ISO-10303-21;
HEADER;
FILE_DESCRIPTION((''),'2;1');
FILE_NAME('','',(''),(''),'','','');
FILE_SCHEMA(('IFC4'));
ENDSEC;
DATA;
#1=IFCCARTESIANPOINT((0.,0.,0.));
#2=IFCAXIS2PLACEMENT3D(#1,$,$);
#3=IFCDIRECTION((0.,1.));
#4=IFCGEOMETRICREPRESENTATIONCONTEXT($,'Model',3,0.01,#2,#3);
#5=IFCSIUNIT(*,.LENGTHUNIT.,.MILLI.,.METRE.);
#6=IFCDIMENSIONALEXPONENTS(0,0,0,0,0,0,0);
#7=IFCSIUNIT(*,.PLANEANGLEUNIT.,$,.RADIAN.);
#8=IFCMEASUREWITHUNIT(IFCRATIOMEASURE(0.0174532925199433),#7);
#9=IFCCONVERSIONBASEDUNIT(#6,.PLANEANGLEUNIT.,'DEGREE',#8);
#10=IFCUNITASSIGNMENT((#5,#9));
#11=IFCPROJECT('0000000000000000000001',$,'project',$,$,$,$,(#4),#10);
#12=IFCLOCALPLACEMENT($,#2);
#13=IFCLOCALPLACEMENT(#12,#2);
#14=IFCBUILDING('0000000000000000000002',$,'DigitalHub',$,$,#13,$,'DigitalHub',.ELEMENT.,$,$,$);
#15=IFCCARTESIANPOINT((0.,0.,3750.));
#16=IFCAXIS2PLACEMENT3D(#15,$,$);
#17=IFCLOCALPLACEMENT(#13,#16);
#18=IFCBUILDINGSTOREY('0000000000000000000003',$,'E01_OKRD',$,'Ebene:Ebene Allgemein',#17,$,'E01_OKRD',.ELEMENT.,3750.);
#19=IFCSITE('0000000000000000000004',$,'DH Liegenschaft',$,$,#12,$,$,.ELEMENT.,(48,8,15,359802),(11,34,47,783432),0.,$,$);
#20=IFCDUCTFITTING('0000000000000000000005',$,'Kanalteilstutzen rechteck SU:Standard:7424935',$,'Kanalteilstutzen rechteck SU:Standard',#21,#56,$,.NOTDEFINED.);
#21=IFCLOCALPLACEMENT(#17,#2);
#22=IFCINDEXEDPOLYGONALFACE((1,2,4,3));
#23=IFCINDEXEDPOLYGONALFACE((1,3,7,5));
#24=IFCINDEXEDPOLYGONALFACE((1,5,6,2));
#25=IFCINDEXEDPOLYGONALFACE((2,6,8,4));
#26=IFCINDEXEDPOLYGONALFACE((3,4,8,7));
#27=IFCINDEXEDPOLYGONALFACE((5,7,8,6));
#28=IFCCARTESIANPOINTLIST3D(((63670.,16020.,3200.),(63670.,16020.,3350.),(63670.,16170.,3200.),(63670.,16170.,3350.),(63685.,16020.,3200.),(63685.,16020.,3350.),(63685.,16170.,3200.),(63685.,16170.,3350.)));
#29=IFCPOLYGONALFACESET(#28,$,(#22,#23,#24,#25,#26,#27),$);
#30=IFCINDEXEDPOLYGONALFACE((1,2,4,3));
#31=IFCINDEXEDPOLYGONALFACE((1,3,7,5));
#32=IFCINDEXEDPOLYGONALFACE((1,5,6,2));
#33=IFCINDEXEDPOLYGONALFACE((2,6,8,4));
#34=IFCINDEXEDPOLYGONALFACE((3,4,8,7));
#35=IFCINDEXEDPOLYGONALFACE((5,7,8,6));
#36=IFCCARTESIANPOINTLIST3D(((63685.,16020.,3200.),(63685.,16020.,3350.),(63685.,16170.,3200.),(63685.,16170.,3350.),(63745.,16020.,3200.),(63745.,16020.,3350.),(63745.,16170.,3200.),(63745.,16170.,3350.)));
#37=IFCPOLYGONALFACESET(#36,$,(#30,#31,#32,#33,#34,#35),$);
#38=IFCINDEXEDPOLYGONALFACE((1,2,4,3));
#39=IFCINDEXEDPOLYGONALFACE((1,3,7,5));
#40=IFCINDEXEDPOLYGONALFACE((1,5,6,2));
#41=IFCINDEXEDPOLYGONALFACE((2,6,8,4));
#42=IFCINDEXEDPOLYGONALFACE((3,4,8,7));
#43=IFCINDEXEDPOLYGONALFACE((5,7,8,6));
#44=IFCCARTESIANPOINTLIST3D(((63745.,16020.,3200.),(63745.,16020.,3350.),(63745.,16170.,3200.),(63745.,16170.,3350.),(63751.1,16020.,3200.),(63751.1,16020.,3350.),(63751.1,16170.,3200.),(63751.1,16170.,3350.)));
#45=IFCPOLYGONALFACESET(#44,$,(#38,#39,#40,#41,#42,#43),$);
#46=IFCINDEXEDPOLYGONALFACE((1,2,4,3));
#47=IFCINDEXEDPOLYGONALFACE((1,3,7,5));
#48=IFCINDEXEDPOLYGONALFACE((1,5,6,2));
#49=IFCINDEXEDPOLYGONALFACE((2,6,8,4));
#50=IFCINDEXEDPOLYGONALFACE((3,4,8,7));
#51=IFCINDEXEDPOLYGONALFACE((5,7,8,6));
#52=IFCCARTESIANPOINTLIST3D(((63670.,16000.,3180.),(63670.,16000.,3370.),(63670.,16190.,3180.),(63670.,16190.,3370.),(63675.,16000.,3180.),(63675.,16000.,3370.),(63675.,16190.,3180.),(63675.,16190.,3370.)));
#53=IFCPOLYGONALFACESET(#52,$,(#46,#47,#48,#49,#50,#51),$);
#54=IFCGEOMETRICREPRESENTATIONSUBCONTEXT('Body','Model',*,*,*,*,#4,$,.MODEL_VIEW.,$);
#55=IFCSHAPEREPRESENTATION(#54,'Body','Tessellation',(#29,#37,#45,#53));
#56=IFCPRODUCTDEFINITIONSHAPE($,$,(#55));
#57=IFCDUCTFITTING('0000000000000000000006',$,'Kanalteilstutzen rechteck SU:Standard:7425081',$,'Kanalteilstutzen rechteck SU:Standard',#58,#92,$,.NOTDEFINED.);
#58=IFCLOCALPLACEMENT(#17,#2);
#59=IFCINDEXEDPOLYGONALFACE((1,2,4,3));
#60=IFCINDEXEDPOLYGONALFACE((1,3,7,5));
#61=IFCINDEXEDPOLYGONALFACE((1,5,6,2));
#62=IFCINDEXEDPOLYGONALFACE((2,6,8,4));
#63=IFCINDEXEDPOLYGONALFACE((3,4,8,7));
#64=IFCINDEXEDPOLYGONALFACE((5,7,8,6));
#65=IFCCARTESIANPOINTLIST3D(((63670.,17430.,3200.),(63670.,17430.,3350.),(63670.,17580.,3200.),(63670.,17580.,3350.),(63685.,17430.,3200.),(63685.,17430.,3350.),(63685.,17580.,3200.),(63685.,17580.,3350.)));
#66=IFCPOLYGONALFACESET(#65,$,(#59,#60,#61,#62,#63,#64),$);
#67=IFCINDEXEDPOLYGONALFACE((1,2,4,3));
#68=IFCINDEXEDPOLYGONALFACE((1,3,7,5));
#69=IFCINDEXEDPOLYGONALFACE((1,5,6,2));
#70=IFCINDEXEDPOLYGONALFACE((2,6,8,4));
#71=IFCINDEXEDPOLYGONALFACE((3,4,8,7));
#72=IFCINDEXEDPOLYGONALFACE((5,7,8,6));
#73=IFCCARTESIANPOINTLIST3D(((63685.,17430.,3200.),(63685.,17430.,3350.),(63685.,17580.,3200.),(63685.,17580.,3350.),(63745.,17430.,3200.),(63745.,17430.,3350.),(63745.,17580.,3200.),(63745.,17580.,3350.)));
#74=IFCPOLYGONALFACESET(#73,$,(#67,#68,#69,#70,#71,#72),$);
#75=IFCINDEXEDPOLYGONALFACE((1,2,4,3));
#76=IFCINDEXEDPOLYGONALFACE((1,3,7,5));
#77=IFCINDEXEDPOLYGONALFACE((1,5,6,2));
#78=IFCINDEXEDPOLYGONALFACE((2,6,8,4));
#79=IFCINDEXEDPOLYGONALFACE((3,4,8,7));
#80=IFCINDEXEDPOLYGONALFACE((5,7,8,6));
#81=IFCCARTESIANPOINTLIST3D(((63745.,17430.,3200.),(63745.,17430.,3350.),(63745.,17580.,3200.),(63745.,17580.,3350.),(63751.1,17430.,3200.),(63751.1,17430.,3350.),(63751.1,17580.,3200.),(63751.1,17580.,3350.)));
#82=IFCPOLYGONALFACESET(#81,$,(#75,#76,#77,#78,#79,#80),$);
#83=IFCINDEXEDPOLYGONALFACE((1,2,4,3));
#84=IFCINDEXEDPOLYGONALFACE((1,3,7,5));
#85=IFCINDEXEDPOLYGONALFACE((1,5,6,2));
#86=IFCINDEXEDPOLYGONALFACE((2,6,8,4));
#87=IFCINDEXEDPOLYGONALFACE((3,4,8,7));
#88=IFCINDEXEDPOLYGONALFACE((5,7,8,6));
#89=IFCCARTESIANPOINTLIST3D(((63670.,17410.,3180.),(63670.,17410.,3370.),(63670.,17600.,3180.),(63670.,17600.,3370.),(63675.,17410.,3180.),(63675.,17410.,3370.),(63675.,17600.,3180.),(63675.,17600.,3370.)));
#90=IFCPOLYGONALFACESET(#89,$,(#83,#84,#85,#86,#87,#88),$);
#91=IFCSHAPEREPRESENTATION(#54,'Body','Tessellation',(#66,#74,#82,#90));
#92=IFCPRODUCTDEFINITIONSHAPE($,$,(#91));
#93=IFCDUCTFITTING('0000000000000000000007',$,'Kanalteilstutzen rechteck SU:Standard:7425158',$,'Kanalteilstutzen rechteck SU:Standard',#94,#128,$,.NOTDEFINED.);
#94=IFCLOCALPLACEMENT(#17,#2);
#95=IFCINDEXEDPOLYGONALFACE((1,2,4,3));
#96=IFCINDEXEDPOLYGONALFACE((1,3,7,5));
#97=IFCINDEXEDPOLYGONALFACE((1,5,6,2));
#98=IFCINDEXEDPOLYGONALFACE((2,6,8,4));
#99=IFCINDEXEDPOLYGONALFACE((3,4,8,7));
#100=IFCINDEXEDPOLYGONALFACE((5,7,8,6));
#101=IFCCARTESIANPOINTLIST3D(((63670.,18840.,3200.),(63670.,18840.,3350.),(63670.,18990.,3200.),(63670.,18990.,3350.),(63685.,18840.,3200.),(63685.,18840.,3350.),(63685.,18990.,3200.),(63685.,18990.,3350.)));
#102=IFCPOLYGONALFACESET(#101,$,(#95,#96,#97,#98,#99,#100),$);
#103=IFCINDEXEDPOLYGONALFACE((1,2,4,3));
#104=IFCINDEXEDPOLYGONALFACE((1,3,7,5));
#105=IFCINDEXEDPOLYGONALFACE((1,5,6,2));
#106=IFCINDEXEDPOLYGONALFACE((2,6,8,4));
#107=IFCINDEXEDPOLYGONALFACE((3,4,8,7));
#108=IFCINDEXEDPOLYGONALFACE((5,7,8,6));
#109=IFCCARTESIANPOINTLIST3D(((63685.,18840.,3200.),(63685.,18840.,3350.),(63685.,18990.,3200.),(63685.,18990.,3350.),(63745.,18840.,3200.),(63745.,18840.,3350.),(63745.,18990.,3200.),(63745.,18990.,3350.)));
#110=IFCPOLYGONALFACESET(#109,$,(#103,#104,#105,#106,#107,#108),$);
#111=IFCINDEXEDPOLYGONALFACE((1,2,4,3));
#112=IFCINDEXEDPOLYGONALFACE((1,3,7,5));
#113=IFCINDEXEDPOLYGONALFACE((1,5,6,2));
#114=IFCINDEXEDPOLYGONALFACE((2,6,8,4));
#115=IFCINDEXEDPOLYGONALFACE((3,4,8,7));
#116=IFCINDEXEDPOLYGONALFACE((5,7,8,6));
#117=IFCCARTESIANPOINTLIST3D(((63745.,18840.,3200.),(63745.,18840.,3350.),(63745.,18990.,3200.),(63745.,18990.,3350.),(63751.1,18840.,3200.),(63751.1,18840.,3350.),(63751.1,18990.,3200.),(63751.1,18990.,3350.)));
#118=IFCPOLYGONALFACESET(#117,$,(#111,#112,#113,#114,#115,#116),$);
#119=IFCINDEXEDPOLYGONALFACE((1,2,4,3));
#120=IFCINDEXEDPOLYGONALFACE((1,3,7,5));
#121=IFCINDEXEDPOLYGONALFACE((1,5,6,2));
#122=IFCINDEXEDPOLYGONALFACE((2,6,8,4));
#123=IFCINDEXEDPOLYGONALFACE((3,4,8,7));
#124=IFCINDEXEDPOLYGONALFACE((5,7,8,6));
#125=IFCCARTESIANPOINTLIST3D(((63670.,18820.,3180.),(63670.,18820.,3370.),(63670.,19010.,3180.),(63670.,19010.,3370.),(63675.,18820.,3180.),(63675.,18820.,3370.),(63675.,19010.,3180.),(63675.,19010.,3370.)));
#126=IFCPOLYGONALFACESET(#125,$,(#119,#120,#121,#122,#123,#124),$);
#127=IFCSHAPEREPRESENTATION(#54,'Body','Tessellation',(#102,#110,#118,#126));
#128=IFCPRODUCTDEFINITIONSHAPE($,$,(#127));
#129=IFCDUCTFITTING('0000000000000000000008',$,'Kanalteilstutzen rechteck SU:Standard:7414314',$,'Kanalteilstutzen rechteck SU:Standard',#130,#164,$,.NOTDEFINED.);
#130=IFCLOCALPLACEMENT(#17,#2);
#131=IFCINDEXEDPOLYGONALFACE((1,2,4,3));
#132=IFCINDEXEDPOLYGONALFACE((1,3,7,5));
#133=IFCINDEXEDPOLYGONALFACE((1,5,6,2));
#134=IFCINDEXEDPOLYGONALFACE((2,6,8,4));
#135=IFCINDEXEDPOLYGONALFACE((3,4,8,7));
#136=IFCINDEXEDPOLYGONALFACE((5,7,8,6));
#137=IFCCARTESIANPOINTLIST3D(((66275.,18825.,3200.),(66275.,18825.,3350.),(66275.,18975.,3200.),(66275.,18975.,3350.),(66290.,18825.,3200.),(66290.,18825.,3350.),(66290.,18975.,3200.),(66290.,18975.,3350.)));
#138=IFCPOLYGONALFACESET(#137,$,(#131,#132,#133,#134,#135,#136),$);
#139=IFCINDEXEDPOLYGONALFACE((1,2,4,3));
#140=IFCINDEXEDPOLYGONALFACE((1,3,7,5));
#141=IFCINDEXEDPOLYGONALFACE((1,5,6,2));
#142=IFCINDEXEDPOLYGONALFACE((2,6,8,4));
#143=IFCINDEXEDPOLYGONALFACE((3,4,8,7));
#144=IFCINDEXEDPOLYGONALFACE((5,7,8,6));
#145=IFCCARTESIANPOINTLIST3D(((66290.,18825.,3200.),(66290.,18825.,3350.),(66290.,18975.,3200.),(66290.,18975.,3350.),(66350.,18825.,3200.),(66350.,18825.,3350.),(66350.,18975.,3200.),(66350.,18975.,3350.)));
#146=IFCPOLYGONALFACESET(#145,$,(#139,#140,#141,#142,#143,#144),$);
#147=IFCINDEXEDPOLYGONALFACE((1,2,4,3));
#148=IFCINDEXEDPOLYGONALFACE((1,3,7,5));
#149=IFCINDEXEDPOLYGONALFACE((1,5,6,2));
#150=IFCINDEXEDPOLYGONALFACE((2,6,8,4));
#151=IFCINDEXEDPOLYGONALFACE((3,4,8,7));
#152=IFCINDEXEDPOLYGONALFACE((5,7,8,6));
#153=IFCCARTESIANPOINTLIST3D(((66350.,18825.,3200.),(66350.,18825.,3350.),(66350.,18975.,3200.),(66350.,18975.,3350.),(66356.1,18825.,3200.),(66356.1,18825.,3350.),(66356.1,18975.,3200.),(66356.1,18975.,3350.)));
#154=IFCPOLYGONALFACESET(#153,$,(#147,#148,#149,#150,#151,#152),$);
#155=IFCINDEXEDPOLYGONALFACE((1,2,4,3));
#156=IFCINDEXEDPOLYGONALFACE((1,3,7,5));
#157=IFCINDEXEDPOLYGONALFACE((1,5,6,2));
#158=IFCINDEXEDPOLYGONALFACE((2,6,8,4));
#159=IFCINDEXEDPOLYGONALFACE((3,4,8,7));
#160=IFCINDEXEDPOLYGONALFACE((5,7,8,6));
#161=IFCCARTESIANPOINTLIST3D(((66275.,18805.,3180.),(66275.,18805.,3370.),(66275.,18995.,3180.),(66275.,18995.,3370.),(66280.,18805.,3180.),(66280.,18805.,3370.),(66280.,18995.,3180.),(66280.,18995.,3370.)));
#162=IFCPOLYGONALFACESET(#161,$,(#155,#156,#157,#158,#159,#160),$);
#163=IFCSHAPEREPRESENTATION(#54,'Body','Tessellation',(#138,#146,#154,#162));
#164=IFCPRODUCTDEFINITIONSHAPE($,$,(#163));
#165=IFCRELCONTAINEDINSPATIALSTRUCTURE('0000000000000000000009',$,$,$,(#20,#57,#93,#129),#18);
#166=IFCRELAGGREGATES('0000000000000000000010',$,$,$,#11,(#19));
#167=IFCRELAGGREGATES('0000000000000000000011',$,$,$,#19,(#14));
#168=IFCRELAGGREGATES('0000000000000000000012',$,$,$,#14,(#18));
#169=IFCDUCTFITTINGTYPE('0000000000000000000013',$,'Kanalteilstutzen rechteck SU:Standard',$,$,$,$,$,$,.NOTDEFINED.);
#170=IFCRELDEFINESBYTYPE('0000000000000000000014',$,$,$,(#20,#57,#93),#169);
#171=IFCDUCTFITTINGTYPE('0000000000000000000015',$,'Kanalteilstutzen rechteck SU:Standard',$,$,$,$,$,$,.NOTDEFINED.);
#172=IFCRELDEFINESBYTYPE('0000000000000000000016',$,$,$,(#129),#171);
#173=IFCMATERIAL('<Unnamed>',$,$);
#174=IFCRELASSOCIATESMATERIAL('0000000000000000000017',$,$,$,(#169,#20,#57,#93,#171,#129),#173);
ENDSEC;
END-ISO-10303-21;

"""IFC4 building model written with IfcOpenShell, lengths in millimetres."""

from ifc_helpers import new_model, entity, si_unit, converted_unit, direction, frame, origin, place, context, subcontext, project, spatial, indexed_curve, outline, extrude, source, transform, mapped, material, type_object, type_shapes, element, save


model = new_model("IFC4")

# Units and contexts
model_context = context("Model", 3, precision=0.01, world=origin(), true_north=direction((0.0, 1.0)))
body_context = subcontext(model_context, "Body", "Model", "MODEL_VIEW")
ifc_project = project(units=[si_unit("LENGTHUNIT", "METRE", prefix="MILLI"), converted_unit("PLANEANGLEUNIT", "DEGREE", entity("IfcRatioMeasure", 0.0174532925199433), si_unit("PLANEANGLEUNIT", "RADIAN"), dimensions=[0, 0, 0, 0, 0, 0, 0])], contexts=[model_context])

# Site, building, storey
site_placement = place(None, origin())
site = spatial("IfcSite", under=ifc_project, at=site_placement, Name="DH Liegenschaft", CompositionType="ELEMENT", RefLatitude=(48, 8, 15, 359802), RefLongitude=(11, 34, 47, 783432), RefElevation=0.0)
building_placement = place(site_placement, origin())
building = spatial("IfcBuilding", under=site, at=building_placement, Name="DigitalHub", LongName="DigitalHub", CompositionType="ELEMENT")
storey_placement = place(building_placement, frame((0.0, 0.0, 3750.0)))
storey = spatial("IfcBuildingStorey", under=building, at=storey_placement, Name="E01_OKRD", ObjectType="Ebene:Ebene Allgemein", LongName="E01_OKRD", CompositionType="ELEMENT", Elevation=3750.0)

# Shared definitions
ifc_material_1 = material(Name="<Unnamed>")

# Duct fittings
duct_fitting_type_1 = type_object("IfcDuctFittingType", Name="Kanalteilstutzen rechteck SU:Standard", PredefinedType="NOTDEFINED", material=ifc_material_1)
shared_shape_1 = source(origin(), body_context, "Body", "SweptSolid", [
    extrude(outline(indexed_curve([(-75.0, -7.5), (75.0, -7.5), (75.0, 7.5), (-75.0, 7.5), (-75.0, -7.5)], self_intersect=False)), frame((67.5, 0.0, -75.0), z_axis=(0.0, 0.0, 1.0), x_axis=(0.0, -1.0, 0.0)), (0.0, 0.0, 1.0), 150.0),
    extrude(outline(indexed_curve([(-75.0, -30.0), (75.0, -30.0), (75.0, 30.0), (-75.0, 30.0), (-75.0, -30.0)], self_intersect=False)), frame((30.0, 0.0, -75.0), z_axis=(0.0, 0.0, 1.0), x_axis=(0.0, -1.0, 0.0)), (0.0, 0.0, 1.0), 150.0),
    extrude(outline(indexed_curve([(-75.0, -3.0), (75.0, -3.0), (75.0, 3.0), (-75.0, 3.0), (-75.0, -3.0)], self_intersect=False)), frame((-3.0, 0.0, -75.0), z_axis=(0.0, 0.0, 1.0), x_axis=(0.0, -1.0, 0.0)), (0.0, 0.0, 1.0), 150.0),
    extrude(outline(indexed_curve([(-95.0, -2.5), (95.0, -2.5), (95.0, 2.5), (-95.0, 2.5), (-95.0, -2.5)], self_intersect=False)), frame((72.5, 0.0, -95.0), z_axis=(0.0, 0.0, 1.0), x_axis=(0.0, -1.0, 0.0)), (0.0, 0.0, 1.0), 190.0),
])
type_shapes(duct_fitting_type_1, [shared_shape_1])
for number, where, z_axis, x_axis, name in (
    (1, (63745.0, 16095.0, 3275.0), (0.0, 0.0, -1.0), (-1.0, 0.0, 0.0), "Kanalteilstutzen rechteck SU:Standard:7424935"),
    (2, (63745.0, 17505.0, 3275.0), (0.0, 0.0, -1.0), (-1.0, 0.0, 0.0), "Kanalteilstutzen rechteck SU:Standard:7425081"),
    (3, (63745.0, 18915.0, 3275.0), (0.0, 0.0, -1.0), (-1.0, 0.0, 0.0), "Kanalteilstutzen rechteck SU:Standard:7425158"),
):
    element("IfcDuctFitting", number, at=place(storey_placement, frame(where, z_axis=z_axis, x_axis=x_axis)), inside=storey, type_object=duct_fitting_type_1, material=ifc_material_1, Name=name, ObjectType="Kanalteilstutzen rechteck SU:Standard", PredefinedType="NOTDEFINED", context=body_context, shape_type="MappedRepresentation", body=[
        mapped(shared_shape_1, transform((0.0, 0.0, 0.0), scale=1.0)),
    ])
duct_fitting_type_2 = type_object("IfcDuctFittingType", Name="Kanalteilstutzen rechteck SU:Standard", PredefinedType="NOTDEFINED", material=ifc_material_1)
shared_shape_2 = source(origin(), body_context, "Body", "SweptSolid", [
    extrude(outline(indexed_curve([(-7.5, -75.0), (7.5, -75.0), (7.5, 75.0), (-7.5, 75.0), (-7.5, -75.0)], self_intersect=False)), frame((67.5, 0.0, -75.0)), (0.0, 0.0, 1.0), 150.0),
    extrude(outline(indexed_curve([(-30.0, -75.0), (30.0, -75.0), (30.0, 75.0), (-30.0, 75.0), (-30.0, -75.0)], self_intersect=False)), frame((30.0, 0.0, -75.0)), (0.0, 0.0, 1.0), 150.0),
    extrude(outline(indexed_curve([(-3.0, -75.0), (3.0, -75.0), (3.0, 75.0), (-3.0, 75.0), (-3.0, -75.0)], self_intersect=False)), frame((-3.0, 0.0, -75.0)), (0.0, 0.0, 1.0), 150.0),
    extrude(outline(indexed_curve([(-2.5, -95.0), (2.5, -95.0), (2.5, 95.0), (-2.5, 95.0), (-2.5, -95.0)], self_intersect=False)), frame((72.5, 0.0, -95.0)), (0.0, 0.0, 1.0), 190.0),
])
type_shapes(duct_fitting_type_2, [shared_shape_2])
duct_fitting_1_placement = place(storey_placement, frame((66350.0, 18900.0, 3275.0), z_axis=(0.0, 0.0, -1.0), x_axis=(-1.0, 0.0, 0.0)))
element("IfcDuctFitting", 4, at=duct_fitting_1_placement, inside=storey, type_object=duct_fitting_type_2, material=ifc_material_1, Name="Kanalteilstutzen rechteck SU:Standard:7414314", ObjectType="Kanalteilstutzen rechteck SU:Standard", PredefinedType="NOTDEFINED", context=body_context, shape_type="MappedRepresentation", body=[
    mapped(shared_shape_2, transform((0.0, 0.0, 0.0), scale=1.0)),
])

save(model, "model.ifc")
